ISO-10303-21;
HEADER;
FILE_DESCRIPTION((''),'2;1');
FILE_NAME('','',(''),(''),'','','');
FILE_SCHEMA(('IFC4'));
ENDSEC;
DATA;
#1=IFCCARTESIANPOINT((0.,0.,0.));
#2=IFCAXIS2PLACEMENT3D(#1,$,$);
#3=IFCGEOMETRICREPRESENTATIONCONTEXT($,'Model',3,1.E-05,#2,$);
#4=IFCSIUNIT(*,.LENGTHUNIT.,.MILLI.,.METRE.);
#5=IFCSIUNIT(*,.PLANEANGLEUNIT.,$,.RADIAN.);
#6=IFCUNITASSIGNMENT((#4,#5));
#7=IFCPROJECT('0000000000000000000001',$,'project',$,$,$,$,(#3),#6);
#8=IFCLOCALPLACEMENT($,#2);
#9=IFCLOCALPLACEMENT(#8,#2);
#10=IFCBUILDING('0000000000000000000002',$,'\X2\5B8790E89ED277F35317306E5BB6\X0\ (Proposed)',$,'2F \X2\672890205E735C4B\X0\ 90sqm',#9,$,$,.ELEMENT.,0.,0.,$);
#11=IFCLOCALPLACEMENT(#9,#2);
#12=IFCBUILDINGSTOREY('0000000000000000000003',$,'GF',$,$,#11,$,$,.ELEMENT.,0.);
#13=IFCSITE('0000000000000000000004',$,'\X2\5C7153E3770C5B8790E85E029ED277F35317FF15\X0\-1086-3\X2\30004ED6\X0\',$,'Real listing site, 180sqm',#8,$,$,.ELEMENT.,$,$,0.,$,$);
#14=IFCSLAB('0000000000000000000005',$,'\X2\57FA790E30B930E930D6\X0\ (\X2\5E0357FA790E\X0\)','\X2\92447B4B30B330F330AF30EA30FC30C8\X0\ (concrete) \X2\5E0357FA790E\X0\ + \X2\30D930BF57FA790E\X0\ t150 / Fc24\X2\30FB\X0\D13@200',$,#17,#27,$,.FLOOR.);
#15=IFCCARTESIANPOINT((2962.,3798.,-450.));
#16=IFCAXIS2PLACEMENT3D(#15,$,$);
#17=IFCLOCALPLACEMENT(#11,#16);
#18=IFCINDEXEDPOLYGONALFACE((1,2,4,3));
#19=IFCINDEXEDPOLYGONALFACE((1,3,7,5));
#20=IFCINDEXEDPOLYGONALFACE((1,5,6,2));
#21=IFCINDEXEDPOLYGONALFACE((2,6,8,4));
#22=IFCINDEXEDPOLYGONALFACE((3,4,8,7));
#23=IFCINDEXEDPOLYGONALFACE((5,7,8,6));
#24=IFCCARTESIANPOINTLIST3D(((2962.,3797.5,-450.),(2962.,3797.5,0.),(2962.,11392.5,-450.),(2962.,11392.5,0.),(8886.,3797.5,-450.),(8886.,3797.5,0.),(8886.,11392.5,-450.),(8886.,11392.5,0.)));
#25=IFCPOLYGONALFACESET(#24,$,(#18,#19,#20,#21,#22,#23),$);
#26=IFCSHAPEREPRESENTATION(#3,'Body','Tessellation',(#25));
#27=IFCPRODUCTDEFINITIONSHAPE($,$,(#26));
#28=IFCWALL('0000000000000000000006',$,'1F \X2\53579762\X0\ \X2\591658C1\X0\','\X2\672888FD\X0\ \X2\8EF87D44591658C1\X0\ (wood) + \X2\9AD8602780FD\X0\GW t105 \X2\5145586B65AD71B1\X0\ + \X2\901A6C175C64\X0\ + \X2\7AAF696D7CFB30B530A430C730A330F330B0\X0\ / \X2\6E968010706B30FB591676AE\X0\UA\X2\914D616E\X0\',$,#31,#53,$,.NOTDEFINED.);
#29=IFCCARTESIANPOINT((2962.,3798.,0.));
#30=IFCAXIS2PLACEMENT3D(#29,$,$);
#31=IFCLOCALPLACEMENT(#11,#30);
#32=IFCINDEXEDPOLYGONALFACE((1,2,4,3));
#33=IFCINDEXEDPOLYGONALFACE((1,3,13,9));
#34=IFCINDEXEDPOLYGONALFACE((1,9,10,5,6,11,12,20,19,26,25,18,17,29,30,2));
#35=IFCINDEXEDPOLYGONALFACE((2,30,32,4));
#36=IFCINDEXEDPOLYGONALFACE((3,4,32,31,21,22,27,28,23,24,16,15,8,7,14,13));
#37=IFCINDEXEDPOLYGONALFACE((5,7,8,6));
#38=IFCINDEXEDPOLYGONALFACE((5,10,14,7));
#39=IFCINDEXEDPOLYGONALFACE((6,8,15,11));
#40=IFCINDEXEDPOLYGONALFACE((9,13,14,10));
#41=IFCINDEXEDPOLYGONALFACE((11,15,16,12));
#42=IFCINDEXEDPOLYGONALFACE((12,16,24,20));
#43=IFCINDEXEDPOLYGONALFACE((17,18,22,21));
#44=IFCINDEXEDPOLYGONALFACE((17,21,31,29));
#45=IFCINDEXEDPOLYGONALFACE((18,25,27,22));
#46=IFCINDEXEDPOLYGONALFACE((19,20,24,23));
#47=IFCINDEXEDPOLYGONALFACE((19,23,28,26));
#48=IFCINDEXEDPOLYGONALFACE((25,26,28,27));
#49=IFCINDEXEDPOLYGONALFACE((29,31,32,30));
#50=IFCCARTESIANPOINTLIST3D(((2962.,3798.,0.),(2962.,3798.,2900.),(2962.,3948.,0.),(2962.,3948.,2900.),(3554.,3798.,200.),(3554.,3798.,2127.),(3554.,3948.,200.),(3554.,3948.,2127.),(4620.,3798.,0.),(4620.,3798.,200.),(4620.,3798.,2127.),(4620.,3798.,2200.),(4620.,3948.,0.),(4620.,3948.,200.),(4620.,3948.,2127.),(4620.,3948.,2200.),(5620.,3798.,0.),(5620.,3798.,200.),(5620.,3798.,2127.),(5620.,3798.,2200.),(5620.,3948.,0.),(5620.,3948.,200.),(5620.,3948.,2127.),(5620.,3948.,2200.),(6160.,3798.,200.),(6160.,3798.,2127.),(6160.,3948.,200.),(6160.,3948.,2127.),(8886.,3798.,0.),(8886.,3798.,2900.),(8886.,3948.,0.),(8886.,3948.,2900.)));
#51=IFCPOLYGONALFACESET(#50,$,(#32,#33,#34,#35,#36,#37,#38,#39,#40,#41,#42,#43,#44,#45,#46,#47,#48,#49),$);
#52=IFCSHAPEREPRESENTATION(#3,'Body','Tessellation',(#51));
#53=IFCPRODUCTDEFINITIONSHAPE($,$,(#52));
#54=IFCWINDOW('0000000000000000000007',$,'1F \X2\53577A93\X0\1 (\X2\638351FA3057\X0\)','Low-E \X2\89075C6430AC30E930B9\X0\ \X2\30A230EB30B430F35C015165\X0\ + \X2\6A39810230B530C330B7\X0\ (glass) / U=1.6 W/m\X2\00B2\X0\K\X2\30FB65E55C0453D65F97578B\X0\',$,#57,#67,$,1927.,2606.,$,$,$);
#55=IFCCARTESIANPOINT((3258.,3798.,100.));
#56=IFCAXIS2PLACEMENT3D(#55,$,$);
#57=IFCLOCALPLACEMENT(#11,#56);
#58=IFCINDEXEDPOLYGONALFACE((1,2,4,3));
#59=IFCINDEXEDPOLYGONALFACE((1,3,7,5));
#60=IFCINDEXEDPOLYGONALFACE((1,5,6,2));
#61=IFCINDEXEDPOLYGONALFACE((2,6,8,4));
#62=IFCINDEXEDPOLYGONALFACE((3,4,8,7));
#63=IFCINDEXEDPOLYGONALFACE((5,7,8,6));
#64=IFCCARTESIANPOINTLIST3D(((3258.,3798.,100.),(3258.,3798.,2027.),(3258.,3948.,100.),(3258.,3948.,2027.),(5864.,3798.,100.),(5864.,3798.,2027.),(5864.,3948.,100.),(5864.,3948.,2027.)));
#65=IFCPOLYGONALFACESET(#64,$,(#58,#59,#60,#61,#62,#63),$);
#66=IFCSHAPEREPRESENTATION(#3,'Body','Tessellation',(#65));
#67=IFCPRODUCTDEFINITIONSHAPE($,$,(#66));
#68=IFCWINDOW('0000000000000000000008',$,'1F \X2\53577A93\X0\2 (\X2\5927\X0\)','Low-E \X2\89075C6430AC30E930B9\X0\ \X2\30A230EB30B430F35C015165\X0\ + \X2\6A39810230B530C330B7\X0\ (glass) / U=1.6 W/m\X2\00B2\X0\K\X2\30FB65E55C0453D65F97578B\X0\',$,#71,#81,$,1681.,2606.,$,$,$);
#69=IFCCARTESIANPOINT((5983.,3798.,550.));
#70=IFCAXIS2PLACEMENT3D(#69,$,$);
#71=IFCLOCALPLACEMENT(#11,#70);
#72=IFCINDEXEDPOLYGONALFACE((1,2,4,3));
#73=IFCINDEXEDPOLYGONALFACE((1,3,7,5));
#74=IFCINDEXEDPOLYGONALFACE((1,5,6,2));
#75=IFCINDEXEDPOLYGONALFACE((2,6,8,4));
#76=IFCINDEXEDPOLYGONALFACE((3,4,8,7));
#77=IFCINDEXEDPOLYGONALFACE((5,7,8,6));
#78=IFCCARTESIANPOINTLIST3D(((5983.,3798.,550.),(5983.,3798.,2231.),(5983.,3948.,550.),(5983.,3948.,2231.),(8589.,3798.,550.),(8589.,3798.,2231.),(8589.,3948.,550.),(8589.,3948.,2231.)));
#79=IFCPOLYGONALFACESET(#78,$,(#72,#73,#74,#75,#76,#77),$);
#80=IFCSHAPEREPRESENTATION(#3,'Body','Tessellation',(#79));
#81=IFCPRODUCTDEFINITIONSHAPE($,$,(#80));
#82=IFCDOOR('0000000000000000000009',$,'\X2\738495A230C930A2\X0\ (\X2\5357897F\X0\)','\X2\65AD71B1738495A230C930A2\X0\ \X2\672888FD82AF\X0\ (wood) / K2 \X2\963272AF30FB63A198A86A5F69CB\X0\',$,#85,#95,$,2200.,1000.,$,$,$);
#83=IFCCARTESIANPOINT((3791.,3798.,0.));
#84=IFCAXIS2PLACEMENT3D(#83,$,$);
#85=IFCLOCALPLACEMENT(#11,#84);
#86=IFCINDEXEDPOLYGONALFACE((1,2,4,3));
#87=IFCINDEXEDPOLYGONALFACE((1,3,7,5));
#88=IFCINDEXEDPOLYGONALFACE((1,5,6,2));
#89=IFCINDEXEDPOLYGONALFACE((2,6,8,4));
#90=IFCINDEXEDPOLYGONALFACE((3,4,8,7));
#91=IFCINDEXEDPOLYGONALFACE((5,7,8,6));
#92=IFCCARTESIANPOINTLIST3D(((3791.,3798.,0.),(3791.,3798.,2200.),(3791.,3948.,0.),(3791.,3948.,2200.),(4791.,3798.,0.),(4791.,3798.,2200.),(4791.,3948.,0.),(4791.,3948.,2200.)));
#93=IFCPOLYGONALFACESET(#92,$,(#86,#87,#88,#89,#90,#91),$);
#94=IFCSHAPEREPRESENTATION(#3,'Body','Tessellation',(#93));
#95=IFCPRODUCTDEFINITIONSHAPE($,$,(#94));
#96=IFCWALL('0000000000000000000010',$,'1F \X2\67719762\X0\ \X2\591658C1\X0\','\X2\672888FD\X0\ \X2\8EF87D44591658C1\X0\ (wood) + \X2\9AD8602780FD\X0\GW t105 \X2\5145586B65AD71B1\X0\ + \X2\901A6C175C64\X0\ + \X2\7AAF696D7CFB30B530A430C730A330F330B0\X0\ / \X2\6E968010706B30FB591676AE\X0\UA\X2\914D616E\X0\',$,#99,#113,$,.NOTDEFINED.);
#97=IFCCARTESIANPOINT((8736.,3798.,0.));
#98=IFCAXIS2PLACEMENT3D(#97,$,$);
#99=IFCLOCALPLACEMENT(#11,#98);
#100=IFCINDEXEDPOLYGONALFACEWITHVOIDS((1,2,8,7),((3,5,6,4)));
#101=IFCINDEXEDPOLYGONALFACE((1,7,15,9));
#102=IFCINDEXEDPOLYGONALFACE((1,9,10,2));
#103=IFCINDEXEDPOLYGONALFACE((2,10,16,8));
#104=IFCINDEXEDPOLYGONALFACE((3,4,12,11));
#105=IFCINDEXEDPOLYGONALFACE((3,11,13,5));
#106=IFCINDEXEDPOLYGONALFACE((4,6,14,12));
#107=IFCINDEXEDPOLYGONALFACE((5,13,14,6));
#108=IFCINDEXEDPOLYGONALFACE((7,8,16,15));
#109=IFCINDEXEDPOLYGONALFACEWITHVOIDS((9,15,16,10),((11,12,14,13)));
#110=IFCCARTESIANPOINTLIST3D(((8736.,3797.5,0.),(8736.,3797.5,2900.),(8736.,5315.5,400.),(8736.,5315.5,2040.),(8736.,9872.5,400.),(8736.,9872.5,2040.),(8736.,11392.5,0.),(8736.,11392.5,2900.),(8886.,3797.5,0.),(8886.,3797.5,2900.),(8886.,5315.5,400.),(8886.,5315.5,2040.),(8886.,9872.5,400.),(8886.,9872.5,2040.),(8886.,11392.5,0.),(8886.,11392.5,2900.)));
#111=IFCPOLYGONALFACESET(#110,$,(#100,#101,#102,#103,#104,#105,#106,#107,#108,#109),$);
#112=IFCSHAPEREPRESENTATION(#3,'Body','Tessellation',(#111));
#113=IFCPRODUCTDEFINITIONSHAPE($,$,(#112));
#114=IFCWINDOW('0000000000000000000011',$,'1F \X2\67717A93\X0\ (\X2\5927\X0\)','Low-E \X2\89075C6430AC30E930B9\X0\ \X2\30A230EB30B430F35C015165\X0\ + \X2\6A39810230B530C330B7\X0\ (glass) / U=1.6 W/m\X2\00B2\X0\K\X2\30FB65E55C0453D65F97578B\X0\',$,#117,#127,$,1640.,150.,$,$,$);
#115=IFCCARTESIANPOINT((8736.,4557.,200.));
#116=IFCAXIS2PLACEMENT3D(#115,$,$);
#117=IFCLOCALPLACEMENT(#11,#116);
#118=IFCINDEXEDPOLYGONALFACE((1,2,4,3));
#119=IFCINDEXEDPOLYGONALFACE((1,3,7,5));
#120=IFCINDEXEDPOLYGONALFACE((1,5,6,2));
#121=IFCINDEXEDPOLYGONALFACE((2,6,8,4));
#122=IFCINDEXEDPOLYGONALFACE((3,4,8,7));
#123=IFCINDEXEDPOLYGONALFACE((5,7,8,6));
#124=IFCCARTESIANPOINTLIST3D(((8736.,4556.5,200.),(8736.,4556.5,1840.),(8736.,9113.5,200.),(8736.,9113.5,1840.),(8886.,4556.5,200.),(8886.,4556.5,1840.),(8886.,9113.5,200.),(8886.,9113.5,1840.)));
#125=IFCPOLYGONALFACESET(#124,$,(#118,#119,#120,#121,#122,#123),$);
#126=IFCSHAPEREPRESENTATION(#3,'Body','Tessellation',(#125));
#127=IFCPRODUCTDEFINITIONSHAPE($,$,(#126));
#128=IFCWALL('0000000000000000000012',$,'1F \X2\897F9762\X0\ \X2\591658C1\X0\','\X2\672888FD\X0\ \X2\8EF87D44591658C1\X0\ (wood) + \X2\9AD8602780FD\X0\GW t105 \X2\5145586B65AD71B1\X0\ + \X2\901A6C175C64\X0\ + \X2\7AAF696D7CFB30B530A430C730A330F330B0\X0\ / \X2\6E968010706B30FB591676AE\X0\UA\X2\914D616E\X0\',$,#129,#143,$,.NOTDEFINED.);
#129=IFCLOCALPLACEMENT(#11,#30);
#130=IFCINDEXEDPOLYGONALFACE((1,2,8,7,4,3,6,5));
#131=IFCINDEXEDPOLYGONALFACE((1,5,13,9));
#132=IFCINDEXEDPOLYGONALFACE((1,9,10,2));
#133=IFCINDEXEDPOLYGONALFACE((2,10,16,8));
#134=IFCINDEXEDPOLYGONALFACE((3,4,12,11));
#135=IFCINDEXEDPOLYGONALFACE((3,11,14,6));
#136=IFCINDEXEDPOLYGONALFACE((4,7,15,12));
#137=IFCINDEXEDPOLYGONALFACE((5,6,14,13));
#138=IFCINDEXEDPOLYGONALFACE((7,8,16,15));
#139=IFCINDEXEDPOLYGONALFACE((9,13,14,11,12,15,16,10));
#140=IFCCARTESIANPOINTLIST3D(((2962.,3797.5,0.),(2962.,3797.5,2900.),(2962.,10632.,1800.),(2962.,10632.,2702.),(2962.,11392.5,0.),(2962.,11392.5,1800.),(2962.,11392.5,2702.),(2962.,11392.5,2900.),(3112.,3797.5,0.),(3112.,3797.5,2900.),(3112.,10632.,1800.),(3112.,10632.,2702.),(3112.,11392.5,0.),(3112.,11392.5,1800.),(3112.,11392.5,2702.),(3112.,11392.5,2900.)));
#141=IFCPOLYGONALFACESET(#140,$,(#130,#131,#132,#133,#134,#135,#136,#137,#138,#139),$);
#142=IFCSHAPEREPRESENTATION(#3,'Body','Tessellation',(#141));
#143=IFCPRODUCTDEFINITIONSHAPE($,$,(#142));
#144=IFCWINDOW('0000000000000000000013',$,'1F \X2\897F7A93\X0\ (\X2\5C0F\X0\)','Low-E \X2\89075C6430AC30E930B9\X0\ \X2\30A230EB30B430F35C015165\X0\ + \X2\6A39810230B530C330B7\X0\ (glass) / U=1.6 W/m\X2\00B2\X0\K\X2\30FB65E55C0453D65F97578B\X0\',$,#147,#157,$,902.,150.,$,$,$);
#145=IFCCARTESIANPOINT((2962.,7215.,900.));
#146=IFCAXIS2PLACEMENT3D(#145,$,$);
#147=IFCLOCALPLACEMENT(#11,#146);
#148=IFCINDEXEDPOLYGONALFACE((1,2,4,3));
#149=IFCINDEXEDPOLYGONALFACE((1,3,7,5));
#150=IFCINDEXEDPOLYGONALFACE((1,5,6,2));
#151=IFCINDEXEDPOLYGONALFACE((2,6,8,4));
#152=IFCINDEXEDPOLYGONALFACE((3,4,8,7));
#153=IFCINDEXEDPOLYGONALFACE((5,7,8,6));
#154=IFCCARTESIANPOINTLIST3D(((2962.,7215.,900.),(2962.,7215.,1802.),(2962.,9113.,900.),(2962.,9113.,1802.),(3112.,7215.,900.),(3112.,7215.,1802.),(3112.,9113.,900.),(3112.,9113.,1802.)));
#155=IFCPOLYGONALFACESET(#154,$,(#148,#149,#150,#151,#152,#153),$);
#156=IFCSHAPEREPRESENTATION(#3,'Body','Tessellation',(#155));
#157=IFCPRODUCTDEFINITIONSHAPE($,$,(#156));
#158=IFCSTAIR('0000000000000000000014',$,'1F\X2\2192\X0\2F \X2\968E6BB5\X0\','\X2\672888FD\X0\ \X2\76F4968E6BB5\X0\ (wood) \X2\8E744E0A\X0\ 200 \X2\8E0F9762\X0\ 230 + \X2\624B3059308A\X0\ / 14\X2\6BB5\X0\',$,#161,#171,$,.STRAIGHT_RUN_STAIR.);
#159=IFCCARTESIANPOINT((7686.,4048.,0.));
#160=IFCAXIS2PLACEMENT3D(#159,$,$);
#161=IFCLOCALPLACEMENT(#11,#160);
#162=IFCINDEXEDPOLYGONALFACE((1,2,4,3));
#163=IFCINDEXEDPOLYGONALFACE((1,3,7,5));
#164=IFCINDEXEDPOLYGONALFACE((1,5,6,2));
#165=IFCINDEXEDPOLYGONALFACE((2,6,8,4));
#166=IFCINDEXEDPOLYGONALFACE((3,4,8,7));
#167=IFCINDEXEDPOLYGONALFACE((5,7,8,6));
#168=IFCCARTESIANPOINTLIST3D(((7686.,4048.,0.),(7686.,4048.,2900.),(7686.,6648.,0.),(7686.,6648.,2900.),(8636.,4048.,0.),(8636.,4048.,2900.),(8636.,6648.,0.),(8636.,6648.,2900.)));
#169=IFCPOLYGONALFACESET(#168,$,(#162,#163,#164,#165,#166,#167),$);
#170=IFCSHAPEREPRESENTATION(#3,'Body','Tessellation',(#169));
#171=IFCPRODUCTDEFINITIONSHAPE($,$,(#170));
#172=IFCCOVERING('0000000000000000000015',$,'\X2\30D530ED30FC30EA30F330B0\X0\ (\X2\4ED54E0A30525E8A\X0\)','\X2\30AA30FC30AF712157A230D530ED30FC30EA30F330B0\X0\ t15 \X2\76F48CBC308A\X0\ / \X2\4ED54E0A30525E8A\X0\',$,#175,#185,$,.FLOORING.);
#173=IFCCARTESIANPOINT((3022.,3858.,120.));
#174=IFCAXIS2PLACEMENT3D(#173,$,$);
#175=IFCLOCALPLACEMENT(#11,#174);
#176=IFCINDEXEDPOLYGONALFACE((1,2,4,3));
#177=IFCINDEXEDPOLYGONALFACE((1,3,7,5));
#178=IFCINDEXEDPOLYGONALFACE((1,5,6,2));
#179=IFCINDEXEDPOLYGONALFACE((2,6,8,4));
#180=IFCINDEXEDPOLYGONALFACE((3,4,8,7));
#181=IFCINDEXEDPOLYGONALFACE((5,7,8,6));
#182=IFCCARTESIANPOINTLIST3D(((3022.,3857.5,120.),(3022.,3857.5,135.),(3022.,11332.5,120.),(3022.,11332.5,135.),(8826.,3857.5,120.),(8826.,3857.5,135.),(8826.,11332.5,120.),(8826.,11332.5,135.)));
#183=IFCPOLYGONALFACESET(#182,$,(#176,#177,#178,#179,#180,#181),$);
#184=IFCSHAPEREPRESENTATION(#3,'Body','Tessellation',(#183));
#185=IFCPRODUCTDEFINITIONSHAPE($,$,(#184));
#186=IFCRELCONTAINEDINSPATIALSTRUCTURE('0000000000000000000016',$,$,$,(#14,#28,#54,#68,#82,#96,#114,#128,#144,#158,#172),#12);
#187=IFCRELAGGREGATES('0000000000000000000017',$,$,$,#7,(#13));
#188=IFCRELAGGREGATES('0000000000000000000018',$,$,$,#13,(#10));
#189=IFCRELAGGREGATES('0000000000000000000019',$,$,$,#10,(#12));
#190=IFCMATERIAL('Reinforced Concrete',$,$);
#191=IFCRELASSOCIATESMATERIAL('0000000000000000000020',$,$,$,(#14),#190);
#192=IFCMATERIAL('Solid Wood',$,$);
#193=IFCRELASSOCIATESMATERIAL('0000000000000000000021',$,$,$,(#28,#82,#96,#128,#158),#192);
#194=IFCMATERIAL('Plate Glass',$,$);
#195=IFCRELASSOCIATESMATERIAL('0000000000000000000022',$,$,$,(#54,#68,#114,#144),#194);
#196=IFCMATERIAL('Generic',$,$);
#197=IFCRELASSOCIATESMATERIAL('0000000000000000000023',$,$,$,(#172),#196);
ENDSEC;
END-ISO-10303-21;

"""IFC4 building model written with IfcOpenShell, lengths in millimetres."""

from ifc_helpers import new_model, si_unit, frame, frame_2d, origin, place, context, project, spatial, rectangle, extrude, material, element, fill, save


model = new_model("IFC4")

# Units and contexts
model_context = context("Model", 3, precision=1e-05, world=origin())
ifc_project = project(units=[si_unit("LENGTHUNIT", "METRE", prefix="MILLI"), si_unit("PLANEANGLEUNIT", "RADIAN")], contexts=[model_context])

# Site, building, storey
site_placement = place(None, origin())
site = spatial("IfcSite", under=ifc_project, at=site_placement, Name="山口県宇部市黒石北５-1086-3　他", ObjectType="Real listing site, 180sqm", CompositionType="ELEMENT", RefElevation=0.0)
building_placement = place(site_placement, origin())
building = spatial("IfcBuilding", under=site, at=building_placement, Name="宇部黒石北の家 (Proposed)", ObjectType="2F 木造平屋 90sqm", CompositionType="ELEMENT", ElevationOfRefHeight=0.0, ElevationOfTerrain=0.0)
storey_placement = place(building_placement, origin())
storey = spatial("IfcBuildingStorey", under=building, at=storey_placement, Name="GF", CompositionType="ELEMENT", Elevation=0.0)

# Slab
ifc_material_1 = material(Name="Reinforced Concrete")
slab_1_placement = place(storey_placement, frame((2962.0, 3798.0, -450.0)))
element("IfcSlab", 1, at=slab_1_placement, inside=storey, material=ifc_material_1, Name="基礎スラブ (布基礎)", Description="鉄筋コンクリート (concrete) 布基礎 + ベタ基礎 t150 / Fc24・D13@200", PredefinedType="FLOOR", context=model_context, shape_type="SweptSolid", body=[
    extrude(rectangle(XDim=5924.0, YDim=7595.0, at=frame_2d((2962.0, 3797.0))), frame((2962.0, 3798.0, -450.0)), (0.0, 0.0, 1.0), 450.0),
])
ifc_material_2 = material(Name="Solid Wood")

# Wall, openings, windows, door
wall_1_placement = place(storey_placement, frame((2962.0, 3798.0, 0.0)))
wall_1 = element("IfcWall", 2, at=wall_1_placement, inside=storey, material=ifc_material_2, Name="1F 南面 外壁", Description="木製 軸組外壁 (wood) + 高性能GW t105 充填断熱 + 通気層 + 窯業系サイディング / 準耐火・外皮UA配慮", PredefinedType="NOTDEFINED", context=model_context, shape_type="SweptSolid", body=[
    extrude(rectangle(XDim=5924.0, YDim=150.0, at=frame_2d((2962.0, 75.0))), frame((2962.0, 3798.0, 0.0)), (0.0, 0.0, 1.0), 2900.0),
])
opening_1_placement = place(storey_placement, frame((3258.0, 3798.0, 100.0)))
opening_1 = element("IfcOpeningElement", 3, at=opening_1_placement, cuts=wall_1, PredefinedType="NOTDEFINED", context=model_context, shape_type="SweptSolid", body=[
    extrude(rectangle(XDim=2606.0, YDim=150.0, at=frame_2d((1303.0, 75.0))), frame((3258.0, 3798.0, 100.0)), (0.0, 0.0, 1.0), 1927.0),
])
opening_2_placement = place(storey_placement, frame((5983.0, 3798.0, 550.0)))
opening_2 = element("IfcOpeningElement", 4, at=opening_2_placement, cuts=wall_1, PredefinedType="NOTDEFINED", context=model_context, shape_type="SweptSolid", body=[
    extrude(rectangle(XDim=2606.0, YDim=150.0, at=frame_2d((1303.0, 75.0))), frame((5983.0, 3798.0, 550.0)), (0.0, 0.0, 1.0), 1681.0),
])
opening_3_placement = place(storey_placement, frame((3791.0, 3798.0, 0.0)))
opening_3 = element("IfcOpeningElement", 5, at=opening_3_placement, cuts=wall_1, PredefinedType="NOTDEFINED", context=model_context, shape_type="SweptSolid", body=[
    extrude(rectangle(XDim=1000.0, YDim=150.0, at=frame_2d((500.0, 75.0))), frame((3791.0, 3798.0, 0.0)), (0.0, 0.0, 1.0), 2200.0),
])
ifc_material_3 = material(Name="Plate Glass")
window_1_placement = place(storey_placement, frame((3258.0, 3798.0, 100.0)))
window_1 = element("IfcWindow", 6, at=window_1_placement, inside=storey, material=ifc_material_3, Name="1F 南窓1 (掃出し)", Description="Low-E 複層ガラス アルゴン封入 + 樹脂サッシ (glass) / U=1.6 W/m²K・日射取得型", OverallHeight=1927.0, OverallWidth=2606.0, context=model_context, shape_type="SweptSolid", body=[
    extrude(rectangle(XDim=2606.0, YDim=150.0, at=frame_2d((1303.0, 75.0))), frame((3258.0, 3798.0, 100.0)), (0.0, 0.0, 1.0), 1927.0),
])
fill(opening_1, window_1)
window_2_placement = place(storey_placement, frame((5983.0, 3798.0, 550.0)))
window_2 = element("IfcWindow", 7, at=window_2_placement, inside=storey, material=ifc_material_3, Name="1F 南窓2 (大)", Description="Low-E 複層ガラス アルゴン封入 + 樹脂サッシ (glass) / U=1.6 W/m²K・日射取得型", OverallHeight=1681.0, OverallWidth=2606.0, context=model_context, shape_type="SweptSolid", body=[
    extrude(rectangle(XDim=2606.0, YDim=150.0, at=frame_2d((1303.0, 75.0))), frame((5983.0, 3798.0, 550.0)), (0.0, 0.0, 1.0), 1681.0),
])
fill(opening_2, window_2)
door_placement = place(storey_placement, frame((3791.0, 3798.0, 0.0)))
door = element("IfcDoor", 8, at=door_placement, inside=storey, material=ifc_material_2, Name="玄関ドア (南西)", Description="断熱玄関ドア 木製芯 (wood) / K2 防犯・採風機構", OverallHeight=2200.0, OverallWidth=1000.0, context=model_context, shape_type="SweptSolid", body=[
    extrude(rectangle(XDim=1000.0, YDim=150.0, at=frame_2d((500.0, 75.0))), frame((3791.0, 3798.0, 0.0)), (0.0, 0.0, 1.0), 2200.0),
])
fill(opening_3, door)

# Walls, openings, windows
wall_2_placement = place(storey_placement, frame((8736.0, 3798.0, 0.0)))
wall_2 = element("IfcWall", 9, at=wall_2_placement, inside=storey, material=ifc_material_2, Name="1F 東面 外壁", Description="木製 軸組外壁 (wood) + 高性能GW t105 充填断熱 + 通気層 + 窯業系サイディング / 準耐火・外皮UA配慮", PredefinedType="NOTDEFINED", context=model_context, shape_type="SweptSolid", body=[
    extrude(rectangle(XDim=150.0, YDim=7595.0, at=frame_2d((75.0, 3797.0))), frame((8736.0, 3798.0, 0.0)), (0.0, 0.0, 1.0), 2900.0),
])
opening_4_placement = place(storey_placement, frame((8736.0, 4557.0, 200.0)))
opening_4 = element("IfcOpeningElement", 10, at=opening_4_placement, cuts=wall_2, PredefinedType="NOTDEFINED", context=model_context, shape_type="SweptSolid", body=[
    extrude(rectangle(XDim=150.0, YDim=4557.0, at=frame_2d((75.0, 2278.0))), frame((8736.0, 4557.0, 200.0)), (0.0, 0.0, 1.0), 1640.0),
])
window_3_placement = place(storey_placement, frame((8736.0, 4557.0, 200.0)))
window_3 = element("IfcWindow", 11, at=window_3_placement, inside=storey, material=ifc_material_3, Name="1F 東窓 (大)", Description="Low-E 複層ガラス アルゴン封入 + 樹脂サッシ (glass) / U=1.6 W/m²K・日射取得型", OverallHeight=1640.0, OverallWidth=150.0, context=model_context, shape_type="SweptSolid", body=[
    extrude(rectangle(XDim=150.0, YDim=4557.0, at=frame_2d((75.0, 2278.0))), frame((8736.0, 4557.0, 200.0)), (0.0, 0.0, 1.0), 1640.0),
])
fill(opening_4, window_3)
wall_3_placement = place(storey_placement, frame((2962.0, 3798.0, 0.0)))
wall_3 = element("IfcWall", 12, at=wall_3_placement, inside=storey, material=ifc_material_2, Name="1F 西面 外壁", Description="木製 軸組外壁 (wood) + 高性能GW t105 充填断熱 + 通気層 + 窯業系サイディング / 準耐火・外皮UA配慮", PredefinedType="NOTDEFINED", context=model_context, shape_type="SweptSolid", body=[
    extrude(rectangle(XDim=150.0, YDim=7595.0, at=frame_2d((75.0, 3797.0))), frame((2962.0, 3798.0, 0.0)), (0.0, 0.0, 1.0), 2900.0),
])
opening_5_placement = place(storey_placement, frame((2962.0, 7215.0, 900.0)))
opening_5 = element("IfcOpeningElement", 13, at=opening_5_placement, cuts=wall_3, PredefinedType="NOTDEFINED", context=model_context, shape_type="SweptSolid", body=[
    extrude(rectangle(XDim=150.0, YDim=1898.0, at=frame_2d((75.0, 949.0))), frame((2962.0, 7215.0, 900.0)), (0.0, 0.0, 1.0), 902.0),
])
window_4_placement = place(storey_placement, frame((2962.0, 7215.0, 900.0)))
window_4 = element("IfcWindow", 14, at=window_4_placement, inside=storey, material=ifc_material_3, Name="1F 西窓 (小)", Description="Low-E 複層ガラス アルゴン封入 + 樹脂サッシ (glass) / U=1.6 W/m²K・日射取得型", OverallHeight=902.0, OverallWidth=150.0, context=model_context, shape_type="SweptSolid", body=[
    extrude(rectangle(XDim=150.0, YDim=1898.0, at=frame_2d((75.0, 949.0))), frame((2962.0, 7215.0, 900.0)), (0.0, 0.0, 1.0), 902.0),
])
fill(opening_5, window_4)

# Stair
stair_placement = place(storey_placement, frame((7686.0, 4048.0, 0.0)))
element("IfcStair", 15, at=stair_placement, inside=storey, material=ifc_material_2, Name="1F→2F 階段", Description="木製 直階段 (wood) 蹴上 200 踏面 230 + 手すり / 14段", PredefinedType="STRAIGHT_RUN_STAIR", context=model_context, shape_type="SweptSolid", body=[
    extrude(rectangle(XDim=950.0, YDim=2600.0, at=frame_2d((475.0, 1300.0))), frame((7686.0, 4048.0, 0.0)), (0.0, 0.0, 1.0), 2900.0),
])

# Covering
ifc_material_4 = material(Name="Generic")
covering_placement = place(storey_placement, frame((3022.0, 3858.0, 120.0)))
element("IfcCovering", 16, at=covering_placement, inside=storey, material=ifc_material_4, Name="フローリング (仕上げ床)", Description="オーク無垢フローリング t15 直貼り / 仕上げ床", PredefinedType="FLOORING", context=model_context, shape_type="SweptSolid", body=[
    extrude(rectangle(XDim=5804.0, YDim=7475.0, at=frame_2d((2902.0, 3737.0))), frame((3022.0, 3858.0, 120.0)), (0.0, 0.0, 1.0), 15.0),
])

save(model, "model.ifc")
